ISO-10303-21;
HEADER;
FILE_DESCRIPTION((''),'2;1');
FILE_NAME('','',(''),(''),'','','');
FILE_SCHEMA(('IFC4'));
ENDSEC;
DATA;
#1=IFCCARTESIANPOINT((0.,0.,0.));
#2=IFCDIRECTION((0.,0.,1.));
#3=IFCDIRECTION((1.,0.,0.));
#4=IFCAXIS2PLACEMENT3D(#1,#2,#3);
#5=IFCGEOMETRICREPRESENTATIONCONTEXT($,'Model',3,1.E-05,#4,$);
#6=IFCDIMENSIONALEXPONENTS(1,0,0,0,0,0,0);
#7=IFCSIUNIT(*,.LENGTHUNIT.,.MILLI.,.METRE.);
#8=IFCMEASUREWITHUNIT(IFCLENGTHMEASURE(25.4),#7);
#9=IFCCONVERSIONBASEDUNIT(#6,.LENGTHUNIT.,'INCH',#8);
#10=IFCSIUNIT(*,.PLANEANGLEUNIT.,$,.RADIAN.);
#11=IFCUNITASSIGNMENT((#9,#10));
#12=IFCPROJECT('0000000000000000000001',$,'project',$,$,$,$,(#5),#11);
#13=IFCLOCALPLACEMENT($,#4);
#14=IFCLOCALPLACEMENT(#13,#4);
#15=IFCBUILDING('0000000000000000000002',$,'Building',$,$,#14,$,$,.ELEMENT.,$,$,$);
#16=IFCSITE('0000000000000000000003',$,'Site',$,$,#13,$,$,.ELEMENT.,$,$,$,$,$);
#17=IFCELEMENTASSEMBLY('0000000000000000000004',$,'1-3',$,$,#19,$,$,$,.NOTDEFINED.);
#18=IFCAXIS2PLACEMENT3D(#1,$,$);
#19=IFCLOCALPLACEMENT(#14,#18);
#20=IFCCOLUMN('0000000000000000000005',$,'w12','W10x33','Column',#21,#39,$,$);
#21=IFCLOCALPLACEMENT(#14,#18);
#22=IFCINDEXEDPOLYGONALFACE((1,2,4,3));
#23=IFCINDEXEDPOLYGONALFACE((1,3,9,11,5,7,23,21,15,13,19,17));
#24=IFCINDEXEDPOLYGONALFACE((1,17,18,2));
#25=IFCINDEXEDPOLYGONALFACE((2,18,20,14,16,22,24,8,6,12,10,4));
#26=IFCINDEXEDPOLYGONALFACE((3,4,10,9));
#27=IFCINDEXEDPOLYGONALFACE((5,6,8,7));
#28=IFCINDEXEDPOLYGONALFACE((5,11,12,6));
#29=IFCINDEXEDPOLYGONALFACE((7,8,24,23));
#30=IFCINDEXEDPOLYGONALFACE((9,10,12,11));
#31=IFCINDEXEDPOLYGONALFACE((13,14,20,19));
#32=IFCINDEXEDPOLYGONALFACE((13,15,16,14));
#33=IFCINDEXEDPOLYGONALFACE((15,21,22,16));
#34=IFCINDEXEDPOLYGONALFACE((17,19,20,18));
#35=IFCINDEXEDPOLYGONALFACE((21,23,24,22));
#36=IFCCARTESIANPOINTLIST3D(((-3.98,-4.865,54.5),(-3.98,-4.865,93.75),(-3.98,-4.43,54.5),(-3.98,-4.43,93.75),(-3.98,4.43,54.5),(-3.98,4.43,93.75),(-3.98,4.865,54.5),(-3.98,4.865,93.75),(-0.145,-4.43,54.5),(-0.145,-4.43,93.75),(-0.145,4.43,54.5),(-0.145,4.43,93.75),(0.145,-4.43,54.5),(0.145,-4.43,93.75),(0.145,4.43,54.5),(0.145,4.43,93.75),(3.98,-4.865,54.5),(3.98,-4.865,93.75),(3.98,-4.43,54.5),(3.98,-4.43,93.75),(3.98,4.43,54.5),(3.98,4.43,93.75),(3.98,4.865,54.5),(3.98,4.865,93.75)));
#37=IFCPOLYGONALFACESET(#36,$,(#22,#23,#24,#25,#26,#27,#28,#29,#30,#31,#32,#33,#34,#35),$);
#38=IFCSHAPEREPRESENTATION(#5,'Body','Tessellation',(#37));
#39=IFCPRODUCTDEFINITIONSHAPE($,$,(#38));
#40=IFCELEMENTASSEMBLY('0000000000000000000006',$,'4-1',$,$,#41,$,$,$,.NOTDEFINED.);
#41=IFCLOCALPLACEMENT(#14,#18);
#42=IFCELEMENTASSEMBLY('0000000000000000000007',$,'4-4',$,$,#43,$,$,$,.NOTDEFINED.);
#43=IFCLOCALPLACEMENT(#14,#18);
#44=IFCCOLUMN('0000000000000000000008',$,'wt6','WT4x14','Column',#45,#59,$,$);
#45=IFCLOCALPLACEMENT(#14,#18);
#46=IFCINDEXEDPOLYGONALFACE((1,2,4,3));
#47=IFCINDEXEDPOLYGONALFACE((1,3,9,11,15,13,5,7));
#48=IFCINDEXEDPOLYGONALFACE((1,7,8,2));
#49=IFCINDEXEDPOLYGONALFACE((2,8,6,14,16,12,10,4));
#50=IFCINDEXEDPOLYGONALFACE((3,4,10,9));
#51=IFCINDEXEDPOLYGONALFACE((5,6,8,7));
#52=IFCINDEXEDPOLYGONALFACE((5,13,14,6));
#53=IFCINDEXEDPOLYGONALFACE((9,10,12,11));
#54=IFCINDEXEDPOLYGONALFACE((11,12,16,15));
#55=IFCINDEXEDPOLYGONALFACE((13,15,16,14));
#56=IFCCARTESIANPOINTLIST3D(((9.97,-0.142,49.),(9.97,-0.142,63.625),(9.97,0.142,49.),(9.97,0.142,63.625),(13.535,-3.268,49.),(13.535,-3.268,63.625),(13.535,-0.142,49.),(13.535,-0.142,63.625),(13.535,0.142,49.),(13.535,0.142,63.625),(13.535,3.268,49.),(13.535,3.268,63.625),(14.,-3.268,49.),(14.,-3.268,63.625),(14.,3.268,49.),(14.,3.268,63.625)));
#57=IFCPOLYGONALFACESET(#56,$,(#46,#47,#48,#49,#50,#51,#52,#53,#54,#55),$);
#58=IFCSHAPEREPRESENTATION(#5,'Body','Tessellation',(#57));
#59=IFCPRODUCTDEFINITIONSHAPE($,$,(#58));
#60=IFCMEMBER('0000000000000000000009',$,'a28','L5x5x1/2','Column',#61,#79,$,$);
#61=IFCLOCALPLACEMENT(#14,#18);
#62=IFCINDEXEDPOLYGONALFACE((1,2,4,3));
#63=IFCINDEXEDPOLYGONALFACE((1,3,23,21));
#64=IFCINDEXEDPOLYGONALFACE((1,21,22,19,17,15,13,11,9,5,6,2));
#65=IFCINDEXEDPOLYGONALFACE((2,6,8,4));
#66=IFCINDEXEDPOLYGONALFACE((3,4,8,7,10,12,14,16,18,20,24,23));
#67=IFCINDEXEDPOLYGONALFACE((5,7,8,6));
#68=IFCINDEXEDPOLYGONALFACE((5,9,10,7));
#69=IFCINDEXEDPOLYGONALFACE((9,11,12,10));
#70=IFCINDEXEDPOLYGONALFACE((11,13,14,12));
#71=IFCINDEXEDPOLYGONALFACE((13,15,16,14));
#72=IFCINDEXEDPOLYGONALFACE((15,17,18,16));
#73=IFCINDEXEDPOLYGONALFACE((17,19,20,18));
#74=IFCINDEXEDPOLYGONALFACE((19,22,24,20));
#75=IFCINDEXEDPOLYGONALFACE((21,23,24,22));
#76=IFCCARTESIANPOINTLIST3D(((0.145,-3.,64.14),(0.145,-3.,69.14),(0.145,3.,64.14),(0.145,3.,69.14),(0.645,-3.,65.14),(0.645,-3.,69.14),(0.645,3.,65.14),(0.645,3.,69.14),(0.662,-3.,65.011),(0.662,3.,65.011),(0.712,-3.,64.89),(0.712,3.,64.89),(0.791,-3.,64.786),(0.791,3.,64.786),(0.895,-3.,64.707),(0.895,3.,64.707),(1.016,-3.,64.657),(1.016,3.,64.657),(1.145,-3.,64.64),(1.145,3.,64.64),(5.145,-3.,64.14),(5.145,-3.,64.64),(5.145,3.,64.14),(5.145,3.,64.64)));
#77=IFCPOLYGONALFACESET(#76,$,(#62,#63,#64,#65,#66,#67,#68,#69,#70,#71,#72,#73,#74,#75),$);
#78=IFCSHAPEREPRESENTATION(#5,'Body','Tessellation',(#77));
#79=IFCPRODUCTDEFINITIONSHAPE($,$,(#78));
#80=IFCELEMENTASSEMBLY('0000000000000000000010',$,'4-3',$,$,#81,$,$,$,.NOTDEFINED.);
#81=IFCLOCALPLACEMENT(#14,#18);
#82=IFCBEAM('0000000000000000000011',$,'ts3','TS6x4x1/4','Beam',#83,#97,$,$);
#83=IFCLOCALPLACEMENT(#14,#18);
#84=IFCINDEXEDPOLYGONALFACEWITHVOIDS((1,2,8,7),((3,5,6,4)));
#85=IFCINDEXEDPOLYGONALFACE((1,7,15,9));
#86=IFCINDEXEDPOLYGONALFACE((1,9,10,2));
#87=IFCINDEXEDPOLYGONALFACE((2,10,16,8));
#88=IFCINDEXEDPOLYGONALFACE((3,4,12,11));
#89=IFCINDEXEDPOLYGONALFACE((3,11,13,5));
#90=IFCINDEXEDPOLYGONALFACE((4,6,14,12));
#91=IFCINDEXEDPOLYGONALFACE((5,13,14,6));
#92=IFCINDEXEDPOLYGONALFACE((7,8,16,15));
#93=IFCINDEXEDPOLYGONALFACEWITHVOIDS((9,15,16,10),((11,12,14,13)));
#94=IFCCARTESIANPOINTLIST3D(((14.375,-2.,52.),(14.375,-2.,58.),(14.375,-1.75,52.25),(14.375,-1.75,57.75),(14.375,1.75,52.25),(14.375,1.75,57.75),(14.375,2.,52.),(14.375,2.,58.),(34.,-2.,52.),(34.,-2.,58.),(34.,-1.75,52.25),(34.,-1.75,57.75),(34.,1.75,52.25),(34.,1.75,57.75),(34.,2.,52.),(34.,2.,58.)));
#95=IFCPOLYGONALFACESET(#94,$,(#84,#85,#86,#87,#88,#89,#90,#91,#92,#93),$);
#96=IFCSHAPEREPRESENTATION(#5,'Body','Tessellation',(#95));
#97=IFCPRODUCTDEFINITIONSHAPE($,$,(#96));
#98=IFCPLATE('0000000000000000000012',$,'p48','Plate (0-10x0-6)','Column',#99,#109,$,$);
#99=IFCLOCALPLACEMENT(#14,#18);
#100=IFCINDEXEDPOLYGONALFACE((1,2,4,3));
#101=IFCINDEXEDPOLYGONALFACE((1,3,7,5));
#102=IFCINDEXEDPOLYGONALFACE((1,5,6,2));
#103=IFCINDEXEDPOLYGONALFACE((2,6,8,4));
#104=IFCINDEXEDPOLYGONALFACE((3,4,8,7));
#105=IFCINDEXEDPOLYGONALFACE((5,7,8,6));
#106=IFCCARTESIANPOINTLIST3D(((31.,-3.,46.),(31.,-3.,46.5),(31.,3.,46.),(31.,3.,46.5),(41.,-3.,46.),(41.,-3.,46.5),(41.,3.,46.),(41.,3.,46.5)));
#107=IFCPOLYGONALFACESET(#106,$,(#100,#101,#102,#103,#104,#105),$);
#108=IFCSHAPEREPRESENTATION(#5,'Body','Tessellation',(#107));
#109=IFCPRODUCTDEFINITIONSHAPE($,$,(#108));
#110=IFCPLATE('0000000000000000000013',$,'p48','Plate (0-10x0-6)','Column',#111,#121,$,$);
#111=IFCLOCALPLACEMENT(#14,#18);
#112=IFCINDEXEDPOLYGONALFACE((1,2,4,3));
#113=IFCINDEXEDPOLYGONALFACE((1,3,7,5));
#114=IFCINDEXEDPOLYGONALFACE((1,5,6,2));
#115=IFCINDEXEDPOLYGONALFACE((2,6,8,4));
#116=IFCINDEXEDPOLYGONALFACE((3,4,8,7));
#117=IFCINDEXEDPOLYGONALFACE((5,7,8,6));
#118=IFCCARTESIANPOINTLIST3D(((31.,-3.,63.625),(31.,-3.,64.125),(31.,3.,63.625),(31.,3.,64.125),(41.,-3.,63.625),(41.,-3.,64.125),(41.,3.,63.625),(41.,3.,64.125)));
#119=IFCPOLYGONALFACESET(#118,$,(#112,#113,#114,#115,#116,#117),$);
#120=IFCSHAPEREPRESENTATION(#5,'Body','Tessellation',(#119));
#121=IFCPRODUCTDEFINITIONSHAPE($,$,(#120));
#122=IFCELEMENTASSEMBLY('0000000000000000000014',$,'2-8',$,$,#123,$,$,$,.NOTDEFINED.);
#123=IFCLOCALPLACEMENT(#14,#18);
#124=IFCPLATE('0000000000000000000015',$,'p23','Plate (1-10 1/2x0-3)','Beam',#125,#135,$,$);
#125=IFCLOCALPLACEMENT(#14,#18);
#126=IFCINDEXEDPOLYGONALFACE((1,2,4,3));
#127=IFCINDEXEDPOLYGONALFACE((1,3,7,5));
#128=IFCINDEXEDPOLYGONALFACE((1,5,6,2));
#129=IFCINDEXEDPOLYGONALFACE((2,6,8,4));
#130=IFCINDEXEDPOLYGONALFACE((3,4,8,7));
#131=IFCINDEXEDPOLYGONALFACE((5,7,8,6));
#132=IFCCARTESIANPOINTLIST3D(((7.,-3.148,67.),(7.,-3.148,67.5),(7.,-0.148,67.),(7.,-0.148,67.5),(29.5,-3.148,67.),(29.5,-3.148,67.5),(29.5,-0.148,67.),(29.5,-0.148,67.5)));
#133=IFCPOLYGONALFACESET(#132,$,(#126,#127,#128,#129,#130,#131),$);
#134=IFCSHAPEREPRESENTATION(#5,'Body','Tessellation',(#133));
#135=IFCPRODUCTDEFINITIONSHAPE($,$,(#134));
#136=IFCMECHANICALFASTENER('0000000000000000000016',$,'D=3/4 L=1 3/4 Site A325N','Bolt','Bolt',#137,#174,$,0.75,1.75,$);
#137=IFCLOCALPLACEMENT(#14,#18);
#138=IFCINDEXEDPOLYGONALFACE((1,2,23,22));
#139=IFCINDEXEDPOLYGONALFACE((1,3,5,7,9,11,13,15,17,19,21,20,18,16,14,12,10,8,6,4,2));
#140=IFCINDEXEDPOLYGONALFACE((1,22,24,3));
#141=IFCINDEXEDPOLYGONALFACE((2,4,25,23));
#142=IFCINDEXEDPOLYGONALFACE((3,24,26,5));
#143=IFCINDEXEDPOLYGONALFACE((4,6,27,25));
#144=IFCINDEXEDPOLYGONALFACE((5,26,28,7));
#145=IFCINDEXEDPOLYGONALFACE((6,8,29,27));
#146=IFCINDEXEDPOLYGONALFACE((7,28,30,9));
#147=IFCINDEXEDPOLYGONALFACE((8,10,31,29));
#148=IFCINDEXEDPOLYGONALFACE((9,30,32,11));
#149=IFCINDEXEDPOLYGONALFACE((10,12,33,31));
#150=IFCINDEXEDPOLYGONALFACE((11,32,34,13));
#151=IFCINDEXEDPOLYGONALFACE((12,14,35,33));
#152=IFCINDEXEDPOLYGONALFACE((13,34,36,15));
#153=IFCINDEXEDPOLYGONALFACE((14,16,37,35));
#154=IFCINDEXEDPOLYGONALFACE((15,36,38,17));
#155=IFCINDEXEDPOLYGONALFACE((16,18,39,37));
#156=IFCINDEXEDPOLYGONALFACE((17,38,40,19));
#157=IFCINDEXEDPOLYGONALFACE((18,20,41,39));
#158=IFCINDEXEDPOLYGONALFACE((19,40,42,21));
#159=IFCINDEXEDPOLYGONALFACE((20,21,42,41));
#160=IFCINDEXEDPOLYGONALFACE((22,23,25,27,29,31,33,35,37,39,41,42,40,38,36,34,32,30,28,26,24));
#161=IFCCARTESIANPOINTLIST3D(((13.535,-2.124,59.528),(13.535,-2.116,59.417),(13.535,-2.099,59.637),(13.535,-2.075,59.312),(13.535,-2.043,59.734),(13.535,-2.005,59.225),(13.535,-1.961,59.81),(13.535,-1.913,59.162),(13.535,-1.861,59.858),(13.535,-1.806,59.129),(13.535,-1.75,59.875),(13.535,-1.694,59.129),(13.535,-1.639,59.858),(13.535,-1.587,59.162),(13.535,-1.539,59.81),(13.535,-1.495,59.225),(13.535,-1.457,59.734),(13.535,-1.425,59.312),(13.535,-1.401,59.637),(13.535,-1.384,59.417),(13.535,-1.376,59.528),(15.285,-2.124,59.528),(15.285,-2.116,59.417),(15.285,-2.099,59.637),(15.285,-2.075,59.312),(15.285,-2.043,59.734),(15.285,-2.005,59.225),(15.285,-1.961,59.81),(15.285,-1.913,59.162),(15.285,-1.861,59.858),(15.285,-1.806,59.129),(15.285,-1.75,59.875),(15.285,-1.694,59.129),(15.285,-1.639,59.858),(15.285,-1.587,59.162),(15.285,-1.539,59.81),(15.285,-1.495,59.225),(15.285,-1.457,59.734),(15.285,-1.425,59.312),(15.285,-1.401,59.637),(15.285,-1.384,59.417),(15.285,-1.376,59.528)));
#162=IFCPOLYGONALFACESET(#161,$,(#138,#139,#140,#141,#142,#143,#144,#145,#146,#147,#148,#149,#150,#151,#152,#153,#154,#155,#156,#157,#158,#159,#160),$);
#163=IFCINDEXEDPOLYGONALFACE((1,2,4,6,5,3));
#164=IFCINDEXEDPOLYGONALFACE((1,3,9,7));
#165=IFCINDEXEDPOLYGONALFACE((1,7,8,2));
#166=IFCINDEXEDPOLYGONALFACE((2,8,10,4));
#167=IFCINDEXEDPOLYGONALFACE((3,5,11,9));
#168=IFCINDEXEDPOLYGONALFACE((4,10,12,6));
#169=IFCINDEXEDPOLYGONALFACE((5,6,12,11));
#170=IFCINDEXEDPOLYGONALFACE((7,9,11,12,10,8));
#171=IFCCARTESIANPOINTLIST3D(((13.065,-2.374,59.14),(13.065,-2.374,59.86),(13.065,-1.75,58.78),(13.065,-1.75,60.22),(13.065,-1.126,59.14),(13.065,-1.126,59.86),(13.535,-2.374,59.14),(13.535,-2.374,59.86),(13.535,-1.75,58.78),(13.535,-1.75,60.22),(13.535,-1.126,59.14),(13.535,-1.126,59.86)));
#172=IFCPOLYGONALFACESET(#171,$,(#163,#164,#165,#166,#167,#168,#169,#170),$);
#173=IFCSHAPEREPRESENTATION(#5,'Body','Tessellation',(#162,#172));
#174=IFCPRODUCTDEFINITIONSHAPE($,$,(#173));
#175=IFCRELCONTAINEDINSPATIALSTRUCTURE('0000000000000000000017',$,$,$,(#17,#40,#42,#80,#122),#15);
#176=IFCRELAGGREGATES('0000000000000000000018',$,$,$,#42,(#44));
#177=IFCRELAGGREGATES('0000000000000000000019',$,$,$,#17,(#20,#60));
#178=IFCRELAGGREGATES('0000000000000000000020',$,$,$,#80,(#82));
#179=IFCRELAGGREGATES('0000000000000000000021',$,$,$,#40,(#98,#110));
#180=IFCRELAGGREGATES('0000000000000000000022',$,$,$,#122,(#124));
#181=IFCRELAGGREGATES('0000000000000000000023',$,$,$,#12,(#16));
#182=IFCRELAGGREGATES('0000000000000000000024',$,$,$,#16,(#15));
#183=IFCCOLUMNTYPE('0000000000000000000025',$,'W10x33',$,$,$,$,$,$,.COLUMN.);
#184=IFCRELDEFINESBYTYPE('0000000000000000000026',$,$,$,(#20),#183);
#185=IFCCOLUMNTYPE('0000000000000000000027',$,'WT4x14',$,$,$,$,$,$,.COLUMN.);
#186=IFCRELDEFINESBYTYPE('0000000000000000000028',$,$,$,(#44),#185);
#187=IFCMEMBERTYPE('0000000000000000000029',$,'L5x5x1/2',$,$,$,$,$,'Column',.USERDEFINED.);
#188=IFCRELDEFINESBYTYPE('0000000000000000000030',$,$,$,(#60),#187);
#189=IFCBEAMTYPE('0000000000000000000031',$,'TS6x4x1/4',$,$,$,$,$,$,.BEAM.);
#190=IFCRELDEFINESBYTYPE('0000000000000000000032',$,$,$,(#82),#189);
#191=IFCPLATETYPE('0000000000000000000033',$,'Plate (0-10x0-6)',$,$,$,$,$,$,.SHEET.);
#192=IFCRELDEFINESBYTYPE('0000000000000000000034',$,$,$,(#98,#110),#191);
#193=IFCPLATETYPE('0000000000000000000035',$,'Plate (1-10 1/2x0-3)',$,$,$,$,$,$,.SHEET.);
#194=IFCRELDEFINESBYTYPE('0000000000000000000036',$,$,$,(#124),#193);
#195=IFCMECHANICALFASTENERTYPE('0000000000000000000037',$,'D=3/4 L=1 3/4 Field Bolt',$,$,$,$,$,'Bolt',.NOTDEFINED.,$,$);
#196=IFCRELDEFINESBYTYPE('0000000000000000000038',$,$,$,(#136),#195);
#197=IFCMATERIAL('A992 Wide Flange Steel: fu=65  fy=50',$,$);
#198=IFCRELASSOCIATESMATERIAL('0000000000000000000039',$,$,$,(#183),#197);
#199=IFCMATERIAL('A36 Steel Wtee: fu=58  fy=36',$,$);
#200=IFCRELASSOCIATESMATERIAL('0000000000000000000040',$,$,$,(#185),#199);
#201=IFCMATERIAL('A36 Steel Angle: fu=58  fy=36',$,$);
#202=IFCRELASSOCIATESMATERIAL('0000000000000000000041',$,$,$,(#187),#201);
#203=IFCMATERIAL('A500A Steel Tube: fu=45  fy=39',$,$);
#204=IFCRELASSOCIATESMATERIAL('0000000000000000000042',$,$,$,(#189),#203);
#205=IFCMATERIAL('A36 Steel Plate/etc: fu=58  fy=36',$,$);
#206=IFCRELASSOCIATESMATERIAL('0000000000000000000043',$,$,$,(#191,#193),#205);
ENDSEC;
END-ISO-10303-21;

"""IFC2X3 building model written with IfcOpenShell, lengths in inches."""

from ifc_helpers import new_model, entity, si_unit, converted_unit, frame, frame_2d, origin_with_axes, origin_2d_with_axis, place, context, project, spatial, polyline, hollow_rectangle, circle, i_section, l_section, t_section, outline, transform_2d, derived_profile, extrude, source, transform, mapped, material, type_object, type_shapes, element, aggregate, save


model = new_model("IFC2X3")

# Units and contexts
model_context = context("Model", 3, precision=1e-05, world=origin_with_axes())
ifc_project = project(units=[converted_unit("LENGTHUNIT", "INCH", entity("IfcLengthMeasure", 25.4), si_unit("LENGTHUNIT", "METRE", prefix="MILLI"), dimensions=[1, 0, 0, 0, 0, 0, 0]), si_unit("PLANEANGLEUNIT", "RADIAN")], contexts=[model_context])

# Site, building
site_placement = place(None, origin_with_axes())
site = spatial("IfcSite", under=ifc_project, at=site_placement, Name="Site", CompositionType="ELEMENT")
building_placement = place(site_placement, origin_with_axes())
building = spatial("IfcBuilding", under=site, at=building_placement, Name="Building", CompositionType="ELEMENT")

# Element assemblies, columns
assembly_1_placement = place(building_placement, frame((0.0, 0.0, 54.5), z_axis=(0.0, -1.0, 0.0), x_axis=(0.0, 0.0, 1.0)))
assembly_1 = element("IfcElementAssembly", 1, at=assembly_1_placement, inside=building, Name="1-3", PredefinedType="NOTDEFINED")
ifc_material_1 = material(Name="A992 Wide Flange Steel: fu=65  fy=50")
column_type_1 = type_object("IfcColumnType", Name="W10x33", PredefinedType="COLUMN", material=ifc_material_1)
shared_shape_1 = source(origin_with_axes(), model_context, "Body", "SweptSolid", [
    extrude(i_section(OverallWidth=7.96, OverallDepth=9.73, WebThickness=0.29, FlangeThickness=0.435, at=origin_2d_with_axis()), frame((0.0, 0.0, 0.0), z_axis=(1.0, 0.0, 0.0), x_axis=(0.0, 1.0, 0.0)), (0.0, 0.0, 1.0), 39.25),
])
type_shapes(column_type_1, [shared_shape_1])
column_1_placement = place(assembly_1_placement, origin_with_axes())
column_1 = element("IfcColumn", 2, at=column_1_placement, type_object=column_type_1, Name="w12", Description="W10x33", ObjectType="Column", context=model_context, shape_type="MappedRepresentation", body=[
    mapped(shared_shape_1, transform((0.0, 0.0, 0.0), scale=1.0)),
])
assembly_2_placement = place(building_placement, frame((36.0, 0.0, 46.0), z_axis=(-1.0, 0.0, 0.0), x_axis=(0.0, 0.0, 1.0)))
assembly_2 = element("IfcElementAssembly", 3, at=assembly_2_placement, inside=building, Name="4-1", PredefinedType="NOTDEFINED")
ifc_material_2 = material(Name="A500A Steel Tube: fu=45  fy=39")
assembly_3_placement = place(building_placement, frame((14.0, 0.0, 49.0), z_axis=(0.0, -1.0, 0.0), x_axis=(0.0, 0.0, 1.0)))
assembly_3 = element("IfcElementAssembly", 4, at=assembly_3_placement, inside=building, Name="4-4", PredefinedType="NOTDEFINED")
ifc_material_3 = material(Name="A36 Steel Wtee: fu=58  fy=36")
column_type_2 = type_object("IfcColumnType", Name="WT4x14", PredefinedType="COLUMN", material=ifc_material_3)
shared_shape_2 = source(origin_with_axes(), model_context, "Body", "SweptSolid", [
    extrude(t_section(Depth=4.03, FlangeWidth=6.535, WebThickness=0.285, FlangeThickness=0.465, at=frame_2d((0.0, -2.015), x_axis=(1.0, 0.0))), frame((0.0, 0.0, 0.0), z_axis=(1.0, 0.0, 0.0), x_axis=(0.0, 1.0, 0.0)), (0.0, 0.0, 1.0), 14.625),
])
type_shapes(column_type_2, [shared_shape_2])
column_2_placement = place(assembly_3_placement, frame((0.0, 0.0, 0.0), z_axis=(0.0, -1.0, 0.0), x_axis=(1.0, 0.0, 0.0)))
column_2 = element("IfcColumn", 5, at=column_2_placement, type_object=column_type_2, Name="wt6", Description="WT4x14", ObjectType="Column", context=model_context, shape_type="MappedRepresentation", body=[
    mapped(shared_shape_2, transform((0.0, 0.0, 0.0), scale=1.0)),
])
aggregate(assembly_3, [column_2])

# Member
ifc_material_4 = material(Name="A36 Steel Angle: fu=58  fy=36")
member_type_1 = type_object("IfcMemberType", Name="L5x5x1/2", ElementType="Column", PredefinedType="USERDEFINED", material=ifc_material_4)
shared_shape_3 = source(origin_with_axes(), model_context, "Body", "SweptSolid", [
    extrude(derived_profile(l_section(Depth=5.0, Width=5.0, Thickness=0.5, FilletRadius=0.5, at=frame_2d((2.5, 2.5), x_axis=(1.0, 0.0))), transform_2d((0.0, 0.0), x_axis=(-1.0, 0.0), y_axis=(0.0, 1.0))), frame((0.0, 0.0, 0.0), z_axis=(1.0, 0.0, 0.0), x_axis=(0.0, 1.0, 0.0)), (0.0, 0.0, 1.0), 6.0),
])
type_shapes(member_type_1, [shared_shape_3])
member_1_placement = place(assembly_1_placement, frame((9.64, -0.145, 3.0), z_axis=(0.0, -1.0, 0.0), x_axis=(0.0, 0.0, -1.0)))
member_1 = element("IfcMember", 6, at=member_1_placement, type_object=member_type_1, Name="a28", Description="L5x5x1/2", ObjectType="Column", context=model_context, shape_type="MappedRepresentation", body=[
    mapped(shared_shape_3, transform((0.0, 0.0, 0.0), scale=1.0)),
])
aggregate(assembly_1, [column_1, member_1])

# Element assembly, beam
assembly_4_placement = place(building_placement, frame((36.0, 0.0, 58.0), z_axis=(0.0, 0.0, 1.0), x_axis=(-1.0, 0.0, 0.0)))
assembly_4 = element("IfcElementAssembly", 7, at=assembly_4_placement, inside=building, Name="4-3", PredefinedType="NOTDEFINED")
beam_type = type_object("IfcBeamType", Name="TS6x4x1/4", PredefinedType="BEAM", material=ifc_material_2)
shared_shape_4 = source(origin_with_axes(), model_context, "Body", "SweptSolid", [
    extrude(hollow_rectangle(XDim=4.0, YDim=6.0, WallThickness=0.25, at=frame_2d((0.0, -3.0), x_axis=(1.0, 0.0))), frame((0.0, 0.0, 0.0), z_axis=(1.0, 0.0, 0.0), x_axis=(0.0, 1.0, 0.0)), (0.0, 0.0, 1.0), 19.625),
])
type_shapes(beam_type, [shared_shape_4])
beam_placement = place(assembly_4_placement, frame((21.625, 0.0, 0.0), z_axis=(0.0, 0.0, 1.0), x_axis=(-1.0, 0.0, 0.0)))
beam = element("IfcBeam", 8, at=beam_placement, type_object=beam_type, Name="ts3", Description="TS6x4x1/4", ObjectType="Beam", context=model_context, shape_type="MappedRepresentation", body=[
    mapped(shared_shape_4, transform((0.0, 0.0, 0.0), scale=1.0)),
])

# Shared definitions
ifc_material_5 = material(Name="A36 Steel Plate/etc: fu=58  fy=36")

# Plates
aggregate(assembly_4, [beam])
plate_type_1 = type_object("IfcPlateType", Name="Plate (0-10x0-6)", PredefinedType="SHEET", material=ifc_material_5)
shared_shape_5 = source(origin_with_axes(), model_context, "Body", "SweptSolid", [
    extrude(outline(polyline([(3.0, -5.0), (-3.0, -5.0), (-3.0, 5.0), (3.0, 5.0), (3.0, -5.0)])), frame((-0.25, 0.0, 0.0), z_axis=(1.0, 0.0, 0.0), x_axis=(0.0, 1.0, 0.0)), (0.0, 0.0, 1.0), 0.5),
])
type_shapes(plate_type_1, [shared_shape_5])
plate_1_placement = place(assembly_2_placement, frame((0.25, 0.0, 0.0), z_axis=(0.0, 0.0, -1.0), x_axis=(1.0, 0.0, 0.0)))
plate_1 = element("IfcPlate", 9, at=plate_1_placement, type_object=plate_type_1, Name="p48", Description="Plate (0-10x0-6)", ObjectType="Column", context=model_context, shape_type="MappedRepresentation", body=[
    mapped(shared_shape_5, transform((0.0, 0.0, 0.0), scale=1.0)),
])
plate_2_placement = place(assembly_2_placement, frame((17.875, 0.0, 0.0), z_axis=(0.0, 0.0, -1.0), x_axis=(-1.0, 0.0, 0.0)))
plate_2 = element("IfcPlate", 10, at=plate_2_placement, type_object=plate_type_1, Name="p48", Description="Plate (0-10x0-6)", ObjectType="Column", context=model_context, shape_type="MappedRepresentation", body=[
    mapped(shared_shape_5, transform((0.0, 0.0, 0.0), scale=1.0)),
])
aggregate(assembly_2, [plate_1, plate_2])

# Element assembly, plate
assembly_5_placement = place(building_placement, frame((0.0, 0.0, 80.0), z_axis=(0.0, 0.0, 1.0), x_axis=(1.0, 0.0, 0.0)))
assembly_5 = element("IfcElementAssembly", 11, at=assembly_5_placement, inside=building, Name="2-8", PredefinedType="NOTDEFINED")
plate_type_2 = type_object("IfcPlateType", Name="Plate (1-10 1/2x0-3)", PredefinedType="SHEET", material=ifc_material_5)
shared_shape_6 = source(origin_with_axes(), model_context, "Body", "SweptSolid", [
    extrude(outline(polyline([(0.0, -22.5), (-3.0, -22.5), (-3.0, 0.0), (0.0, 0.0), (0.0, -22.5)])), frame((-0.25, 0.0, 0.0), z_axis=(1.0, 0.0, 0.0), x_axis=(0.0, 1.0, 0.0)), (0.0, 0.0, 1.0), 0.5),
])
type_shapes(plate_type_2, [shared_shape_6])
plate_3_placement = place(assembly_5_placement, frame((7.0, -0.148, -12.75), z_axis=(-1.0, 0.0, 0.0), x_axis=(0.0, 0.0, 1.0)))
plate_3 = element("IfcPlate", 12, at=plate_3_placement, type_object=plate_type_2, Name="p23", Description="Plate (1-10 1/2x0-3)", ObjectType="Beam", context=model_context, shape_type="MappedRepresentation", body=[
    mapped(shared_shape_6, transform((0.0, 0.0, 0.0), scale=1.0)),
])
aggregate(assembly_5, [plate_3])

# Mechanical fastener
mechanical_fastener_type_1 = type_object("IfcMechanicalFastenerType", Name="D=3/4 L=1 3/4 Field Bolt", ElementType="Bolt")
shared_shape_7 = source(origin_with_axes(), model_context, "Body", "SweptSolid", [
    extrude(circle(Radius=0.375, at=origin_2d_with_axis()), frame((0.0, 0.0, 0.0), z_axis=(1.0, 0.0, 0.0), x_axis=(0.0, 1.0, 0.0)), (0.0, 0.0, 1.0), 1.75),
    extrude(outline(polyline([(-0.72, 0.0), (-0.36, 0.624), (0.36, 0.624), (0.72, 0.0), (0.36, -0.624), (-0.36, -0.624), (-0.72, 0.0)])), frame((0.0, 0.0, 0.0), z_axis=(1.0, 0.0, 0.0), x_axis=(0.0, 1.0, 0.0)), (0.0, 0.0, -1.0), 0.47),
])
type_shapes(mechanical_fastener_type_1, [shared_shape_7])
placement_1 = place(assembly_4_placement, frame((22.465, 1.75, 1.5), z_axis=(0.0, 1.0, 0.0), x_axis=(-1.0, 0.0, 0.0)))
for number, where, z_axis, x_axis, name in (
    (13, (0.0, 0.0, 0.0), (0.0, 0.0, 1.0), (1.0, 0.0, 0.0), "D=3/4 L=1 3/4 Site A325N"),
):
    element("IfcMechanicalFastener", number, at=place(placement_1, frame(where, z_axis=z_axis, x_axis=x_axis)), type_object=mechanical_fastener_type_1, Name=name, Description="Bolt", ObjectType="Bolt", NominalDiameter=0.75, NominalLength=1.75, context=model_context, shape_type="MappedRepresentation", body=[
        mapped(shared_shape_7, transform((0.0, 0.0, 0.0), scale=1.0)),
    ])

save(model, "model.ifc")
